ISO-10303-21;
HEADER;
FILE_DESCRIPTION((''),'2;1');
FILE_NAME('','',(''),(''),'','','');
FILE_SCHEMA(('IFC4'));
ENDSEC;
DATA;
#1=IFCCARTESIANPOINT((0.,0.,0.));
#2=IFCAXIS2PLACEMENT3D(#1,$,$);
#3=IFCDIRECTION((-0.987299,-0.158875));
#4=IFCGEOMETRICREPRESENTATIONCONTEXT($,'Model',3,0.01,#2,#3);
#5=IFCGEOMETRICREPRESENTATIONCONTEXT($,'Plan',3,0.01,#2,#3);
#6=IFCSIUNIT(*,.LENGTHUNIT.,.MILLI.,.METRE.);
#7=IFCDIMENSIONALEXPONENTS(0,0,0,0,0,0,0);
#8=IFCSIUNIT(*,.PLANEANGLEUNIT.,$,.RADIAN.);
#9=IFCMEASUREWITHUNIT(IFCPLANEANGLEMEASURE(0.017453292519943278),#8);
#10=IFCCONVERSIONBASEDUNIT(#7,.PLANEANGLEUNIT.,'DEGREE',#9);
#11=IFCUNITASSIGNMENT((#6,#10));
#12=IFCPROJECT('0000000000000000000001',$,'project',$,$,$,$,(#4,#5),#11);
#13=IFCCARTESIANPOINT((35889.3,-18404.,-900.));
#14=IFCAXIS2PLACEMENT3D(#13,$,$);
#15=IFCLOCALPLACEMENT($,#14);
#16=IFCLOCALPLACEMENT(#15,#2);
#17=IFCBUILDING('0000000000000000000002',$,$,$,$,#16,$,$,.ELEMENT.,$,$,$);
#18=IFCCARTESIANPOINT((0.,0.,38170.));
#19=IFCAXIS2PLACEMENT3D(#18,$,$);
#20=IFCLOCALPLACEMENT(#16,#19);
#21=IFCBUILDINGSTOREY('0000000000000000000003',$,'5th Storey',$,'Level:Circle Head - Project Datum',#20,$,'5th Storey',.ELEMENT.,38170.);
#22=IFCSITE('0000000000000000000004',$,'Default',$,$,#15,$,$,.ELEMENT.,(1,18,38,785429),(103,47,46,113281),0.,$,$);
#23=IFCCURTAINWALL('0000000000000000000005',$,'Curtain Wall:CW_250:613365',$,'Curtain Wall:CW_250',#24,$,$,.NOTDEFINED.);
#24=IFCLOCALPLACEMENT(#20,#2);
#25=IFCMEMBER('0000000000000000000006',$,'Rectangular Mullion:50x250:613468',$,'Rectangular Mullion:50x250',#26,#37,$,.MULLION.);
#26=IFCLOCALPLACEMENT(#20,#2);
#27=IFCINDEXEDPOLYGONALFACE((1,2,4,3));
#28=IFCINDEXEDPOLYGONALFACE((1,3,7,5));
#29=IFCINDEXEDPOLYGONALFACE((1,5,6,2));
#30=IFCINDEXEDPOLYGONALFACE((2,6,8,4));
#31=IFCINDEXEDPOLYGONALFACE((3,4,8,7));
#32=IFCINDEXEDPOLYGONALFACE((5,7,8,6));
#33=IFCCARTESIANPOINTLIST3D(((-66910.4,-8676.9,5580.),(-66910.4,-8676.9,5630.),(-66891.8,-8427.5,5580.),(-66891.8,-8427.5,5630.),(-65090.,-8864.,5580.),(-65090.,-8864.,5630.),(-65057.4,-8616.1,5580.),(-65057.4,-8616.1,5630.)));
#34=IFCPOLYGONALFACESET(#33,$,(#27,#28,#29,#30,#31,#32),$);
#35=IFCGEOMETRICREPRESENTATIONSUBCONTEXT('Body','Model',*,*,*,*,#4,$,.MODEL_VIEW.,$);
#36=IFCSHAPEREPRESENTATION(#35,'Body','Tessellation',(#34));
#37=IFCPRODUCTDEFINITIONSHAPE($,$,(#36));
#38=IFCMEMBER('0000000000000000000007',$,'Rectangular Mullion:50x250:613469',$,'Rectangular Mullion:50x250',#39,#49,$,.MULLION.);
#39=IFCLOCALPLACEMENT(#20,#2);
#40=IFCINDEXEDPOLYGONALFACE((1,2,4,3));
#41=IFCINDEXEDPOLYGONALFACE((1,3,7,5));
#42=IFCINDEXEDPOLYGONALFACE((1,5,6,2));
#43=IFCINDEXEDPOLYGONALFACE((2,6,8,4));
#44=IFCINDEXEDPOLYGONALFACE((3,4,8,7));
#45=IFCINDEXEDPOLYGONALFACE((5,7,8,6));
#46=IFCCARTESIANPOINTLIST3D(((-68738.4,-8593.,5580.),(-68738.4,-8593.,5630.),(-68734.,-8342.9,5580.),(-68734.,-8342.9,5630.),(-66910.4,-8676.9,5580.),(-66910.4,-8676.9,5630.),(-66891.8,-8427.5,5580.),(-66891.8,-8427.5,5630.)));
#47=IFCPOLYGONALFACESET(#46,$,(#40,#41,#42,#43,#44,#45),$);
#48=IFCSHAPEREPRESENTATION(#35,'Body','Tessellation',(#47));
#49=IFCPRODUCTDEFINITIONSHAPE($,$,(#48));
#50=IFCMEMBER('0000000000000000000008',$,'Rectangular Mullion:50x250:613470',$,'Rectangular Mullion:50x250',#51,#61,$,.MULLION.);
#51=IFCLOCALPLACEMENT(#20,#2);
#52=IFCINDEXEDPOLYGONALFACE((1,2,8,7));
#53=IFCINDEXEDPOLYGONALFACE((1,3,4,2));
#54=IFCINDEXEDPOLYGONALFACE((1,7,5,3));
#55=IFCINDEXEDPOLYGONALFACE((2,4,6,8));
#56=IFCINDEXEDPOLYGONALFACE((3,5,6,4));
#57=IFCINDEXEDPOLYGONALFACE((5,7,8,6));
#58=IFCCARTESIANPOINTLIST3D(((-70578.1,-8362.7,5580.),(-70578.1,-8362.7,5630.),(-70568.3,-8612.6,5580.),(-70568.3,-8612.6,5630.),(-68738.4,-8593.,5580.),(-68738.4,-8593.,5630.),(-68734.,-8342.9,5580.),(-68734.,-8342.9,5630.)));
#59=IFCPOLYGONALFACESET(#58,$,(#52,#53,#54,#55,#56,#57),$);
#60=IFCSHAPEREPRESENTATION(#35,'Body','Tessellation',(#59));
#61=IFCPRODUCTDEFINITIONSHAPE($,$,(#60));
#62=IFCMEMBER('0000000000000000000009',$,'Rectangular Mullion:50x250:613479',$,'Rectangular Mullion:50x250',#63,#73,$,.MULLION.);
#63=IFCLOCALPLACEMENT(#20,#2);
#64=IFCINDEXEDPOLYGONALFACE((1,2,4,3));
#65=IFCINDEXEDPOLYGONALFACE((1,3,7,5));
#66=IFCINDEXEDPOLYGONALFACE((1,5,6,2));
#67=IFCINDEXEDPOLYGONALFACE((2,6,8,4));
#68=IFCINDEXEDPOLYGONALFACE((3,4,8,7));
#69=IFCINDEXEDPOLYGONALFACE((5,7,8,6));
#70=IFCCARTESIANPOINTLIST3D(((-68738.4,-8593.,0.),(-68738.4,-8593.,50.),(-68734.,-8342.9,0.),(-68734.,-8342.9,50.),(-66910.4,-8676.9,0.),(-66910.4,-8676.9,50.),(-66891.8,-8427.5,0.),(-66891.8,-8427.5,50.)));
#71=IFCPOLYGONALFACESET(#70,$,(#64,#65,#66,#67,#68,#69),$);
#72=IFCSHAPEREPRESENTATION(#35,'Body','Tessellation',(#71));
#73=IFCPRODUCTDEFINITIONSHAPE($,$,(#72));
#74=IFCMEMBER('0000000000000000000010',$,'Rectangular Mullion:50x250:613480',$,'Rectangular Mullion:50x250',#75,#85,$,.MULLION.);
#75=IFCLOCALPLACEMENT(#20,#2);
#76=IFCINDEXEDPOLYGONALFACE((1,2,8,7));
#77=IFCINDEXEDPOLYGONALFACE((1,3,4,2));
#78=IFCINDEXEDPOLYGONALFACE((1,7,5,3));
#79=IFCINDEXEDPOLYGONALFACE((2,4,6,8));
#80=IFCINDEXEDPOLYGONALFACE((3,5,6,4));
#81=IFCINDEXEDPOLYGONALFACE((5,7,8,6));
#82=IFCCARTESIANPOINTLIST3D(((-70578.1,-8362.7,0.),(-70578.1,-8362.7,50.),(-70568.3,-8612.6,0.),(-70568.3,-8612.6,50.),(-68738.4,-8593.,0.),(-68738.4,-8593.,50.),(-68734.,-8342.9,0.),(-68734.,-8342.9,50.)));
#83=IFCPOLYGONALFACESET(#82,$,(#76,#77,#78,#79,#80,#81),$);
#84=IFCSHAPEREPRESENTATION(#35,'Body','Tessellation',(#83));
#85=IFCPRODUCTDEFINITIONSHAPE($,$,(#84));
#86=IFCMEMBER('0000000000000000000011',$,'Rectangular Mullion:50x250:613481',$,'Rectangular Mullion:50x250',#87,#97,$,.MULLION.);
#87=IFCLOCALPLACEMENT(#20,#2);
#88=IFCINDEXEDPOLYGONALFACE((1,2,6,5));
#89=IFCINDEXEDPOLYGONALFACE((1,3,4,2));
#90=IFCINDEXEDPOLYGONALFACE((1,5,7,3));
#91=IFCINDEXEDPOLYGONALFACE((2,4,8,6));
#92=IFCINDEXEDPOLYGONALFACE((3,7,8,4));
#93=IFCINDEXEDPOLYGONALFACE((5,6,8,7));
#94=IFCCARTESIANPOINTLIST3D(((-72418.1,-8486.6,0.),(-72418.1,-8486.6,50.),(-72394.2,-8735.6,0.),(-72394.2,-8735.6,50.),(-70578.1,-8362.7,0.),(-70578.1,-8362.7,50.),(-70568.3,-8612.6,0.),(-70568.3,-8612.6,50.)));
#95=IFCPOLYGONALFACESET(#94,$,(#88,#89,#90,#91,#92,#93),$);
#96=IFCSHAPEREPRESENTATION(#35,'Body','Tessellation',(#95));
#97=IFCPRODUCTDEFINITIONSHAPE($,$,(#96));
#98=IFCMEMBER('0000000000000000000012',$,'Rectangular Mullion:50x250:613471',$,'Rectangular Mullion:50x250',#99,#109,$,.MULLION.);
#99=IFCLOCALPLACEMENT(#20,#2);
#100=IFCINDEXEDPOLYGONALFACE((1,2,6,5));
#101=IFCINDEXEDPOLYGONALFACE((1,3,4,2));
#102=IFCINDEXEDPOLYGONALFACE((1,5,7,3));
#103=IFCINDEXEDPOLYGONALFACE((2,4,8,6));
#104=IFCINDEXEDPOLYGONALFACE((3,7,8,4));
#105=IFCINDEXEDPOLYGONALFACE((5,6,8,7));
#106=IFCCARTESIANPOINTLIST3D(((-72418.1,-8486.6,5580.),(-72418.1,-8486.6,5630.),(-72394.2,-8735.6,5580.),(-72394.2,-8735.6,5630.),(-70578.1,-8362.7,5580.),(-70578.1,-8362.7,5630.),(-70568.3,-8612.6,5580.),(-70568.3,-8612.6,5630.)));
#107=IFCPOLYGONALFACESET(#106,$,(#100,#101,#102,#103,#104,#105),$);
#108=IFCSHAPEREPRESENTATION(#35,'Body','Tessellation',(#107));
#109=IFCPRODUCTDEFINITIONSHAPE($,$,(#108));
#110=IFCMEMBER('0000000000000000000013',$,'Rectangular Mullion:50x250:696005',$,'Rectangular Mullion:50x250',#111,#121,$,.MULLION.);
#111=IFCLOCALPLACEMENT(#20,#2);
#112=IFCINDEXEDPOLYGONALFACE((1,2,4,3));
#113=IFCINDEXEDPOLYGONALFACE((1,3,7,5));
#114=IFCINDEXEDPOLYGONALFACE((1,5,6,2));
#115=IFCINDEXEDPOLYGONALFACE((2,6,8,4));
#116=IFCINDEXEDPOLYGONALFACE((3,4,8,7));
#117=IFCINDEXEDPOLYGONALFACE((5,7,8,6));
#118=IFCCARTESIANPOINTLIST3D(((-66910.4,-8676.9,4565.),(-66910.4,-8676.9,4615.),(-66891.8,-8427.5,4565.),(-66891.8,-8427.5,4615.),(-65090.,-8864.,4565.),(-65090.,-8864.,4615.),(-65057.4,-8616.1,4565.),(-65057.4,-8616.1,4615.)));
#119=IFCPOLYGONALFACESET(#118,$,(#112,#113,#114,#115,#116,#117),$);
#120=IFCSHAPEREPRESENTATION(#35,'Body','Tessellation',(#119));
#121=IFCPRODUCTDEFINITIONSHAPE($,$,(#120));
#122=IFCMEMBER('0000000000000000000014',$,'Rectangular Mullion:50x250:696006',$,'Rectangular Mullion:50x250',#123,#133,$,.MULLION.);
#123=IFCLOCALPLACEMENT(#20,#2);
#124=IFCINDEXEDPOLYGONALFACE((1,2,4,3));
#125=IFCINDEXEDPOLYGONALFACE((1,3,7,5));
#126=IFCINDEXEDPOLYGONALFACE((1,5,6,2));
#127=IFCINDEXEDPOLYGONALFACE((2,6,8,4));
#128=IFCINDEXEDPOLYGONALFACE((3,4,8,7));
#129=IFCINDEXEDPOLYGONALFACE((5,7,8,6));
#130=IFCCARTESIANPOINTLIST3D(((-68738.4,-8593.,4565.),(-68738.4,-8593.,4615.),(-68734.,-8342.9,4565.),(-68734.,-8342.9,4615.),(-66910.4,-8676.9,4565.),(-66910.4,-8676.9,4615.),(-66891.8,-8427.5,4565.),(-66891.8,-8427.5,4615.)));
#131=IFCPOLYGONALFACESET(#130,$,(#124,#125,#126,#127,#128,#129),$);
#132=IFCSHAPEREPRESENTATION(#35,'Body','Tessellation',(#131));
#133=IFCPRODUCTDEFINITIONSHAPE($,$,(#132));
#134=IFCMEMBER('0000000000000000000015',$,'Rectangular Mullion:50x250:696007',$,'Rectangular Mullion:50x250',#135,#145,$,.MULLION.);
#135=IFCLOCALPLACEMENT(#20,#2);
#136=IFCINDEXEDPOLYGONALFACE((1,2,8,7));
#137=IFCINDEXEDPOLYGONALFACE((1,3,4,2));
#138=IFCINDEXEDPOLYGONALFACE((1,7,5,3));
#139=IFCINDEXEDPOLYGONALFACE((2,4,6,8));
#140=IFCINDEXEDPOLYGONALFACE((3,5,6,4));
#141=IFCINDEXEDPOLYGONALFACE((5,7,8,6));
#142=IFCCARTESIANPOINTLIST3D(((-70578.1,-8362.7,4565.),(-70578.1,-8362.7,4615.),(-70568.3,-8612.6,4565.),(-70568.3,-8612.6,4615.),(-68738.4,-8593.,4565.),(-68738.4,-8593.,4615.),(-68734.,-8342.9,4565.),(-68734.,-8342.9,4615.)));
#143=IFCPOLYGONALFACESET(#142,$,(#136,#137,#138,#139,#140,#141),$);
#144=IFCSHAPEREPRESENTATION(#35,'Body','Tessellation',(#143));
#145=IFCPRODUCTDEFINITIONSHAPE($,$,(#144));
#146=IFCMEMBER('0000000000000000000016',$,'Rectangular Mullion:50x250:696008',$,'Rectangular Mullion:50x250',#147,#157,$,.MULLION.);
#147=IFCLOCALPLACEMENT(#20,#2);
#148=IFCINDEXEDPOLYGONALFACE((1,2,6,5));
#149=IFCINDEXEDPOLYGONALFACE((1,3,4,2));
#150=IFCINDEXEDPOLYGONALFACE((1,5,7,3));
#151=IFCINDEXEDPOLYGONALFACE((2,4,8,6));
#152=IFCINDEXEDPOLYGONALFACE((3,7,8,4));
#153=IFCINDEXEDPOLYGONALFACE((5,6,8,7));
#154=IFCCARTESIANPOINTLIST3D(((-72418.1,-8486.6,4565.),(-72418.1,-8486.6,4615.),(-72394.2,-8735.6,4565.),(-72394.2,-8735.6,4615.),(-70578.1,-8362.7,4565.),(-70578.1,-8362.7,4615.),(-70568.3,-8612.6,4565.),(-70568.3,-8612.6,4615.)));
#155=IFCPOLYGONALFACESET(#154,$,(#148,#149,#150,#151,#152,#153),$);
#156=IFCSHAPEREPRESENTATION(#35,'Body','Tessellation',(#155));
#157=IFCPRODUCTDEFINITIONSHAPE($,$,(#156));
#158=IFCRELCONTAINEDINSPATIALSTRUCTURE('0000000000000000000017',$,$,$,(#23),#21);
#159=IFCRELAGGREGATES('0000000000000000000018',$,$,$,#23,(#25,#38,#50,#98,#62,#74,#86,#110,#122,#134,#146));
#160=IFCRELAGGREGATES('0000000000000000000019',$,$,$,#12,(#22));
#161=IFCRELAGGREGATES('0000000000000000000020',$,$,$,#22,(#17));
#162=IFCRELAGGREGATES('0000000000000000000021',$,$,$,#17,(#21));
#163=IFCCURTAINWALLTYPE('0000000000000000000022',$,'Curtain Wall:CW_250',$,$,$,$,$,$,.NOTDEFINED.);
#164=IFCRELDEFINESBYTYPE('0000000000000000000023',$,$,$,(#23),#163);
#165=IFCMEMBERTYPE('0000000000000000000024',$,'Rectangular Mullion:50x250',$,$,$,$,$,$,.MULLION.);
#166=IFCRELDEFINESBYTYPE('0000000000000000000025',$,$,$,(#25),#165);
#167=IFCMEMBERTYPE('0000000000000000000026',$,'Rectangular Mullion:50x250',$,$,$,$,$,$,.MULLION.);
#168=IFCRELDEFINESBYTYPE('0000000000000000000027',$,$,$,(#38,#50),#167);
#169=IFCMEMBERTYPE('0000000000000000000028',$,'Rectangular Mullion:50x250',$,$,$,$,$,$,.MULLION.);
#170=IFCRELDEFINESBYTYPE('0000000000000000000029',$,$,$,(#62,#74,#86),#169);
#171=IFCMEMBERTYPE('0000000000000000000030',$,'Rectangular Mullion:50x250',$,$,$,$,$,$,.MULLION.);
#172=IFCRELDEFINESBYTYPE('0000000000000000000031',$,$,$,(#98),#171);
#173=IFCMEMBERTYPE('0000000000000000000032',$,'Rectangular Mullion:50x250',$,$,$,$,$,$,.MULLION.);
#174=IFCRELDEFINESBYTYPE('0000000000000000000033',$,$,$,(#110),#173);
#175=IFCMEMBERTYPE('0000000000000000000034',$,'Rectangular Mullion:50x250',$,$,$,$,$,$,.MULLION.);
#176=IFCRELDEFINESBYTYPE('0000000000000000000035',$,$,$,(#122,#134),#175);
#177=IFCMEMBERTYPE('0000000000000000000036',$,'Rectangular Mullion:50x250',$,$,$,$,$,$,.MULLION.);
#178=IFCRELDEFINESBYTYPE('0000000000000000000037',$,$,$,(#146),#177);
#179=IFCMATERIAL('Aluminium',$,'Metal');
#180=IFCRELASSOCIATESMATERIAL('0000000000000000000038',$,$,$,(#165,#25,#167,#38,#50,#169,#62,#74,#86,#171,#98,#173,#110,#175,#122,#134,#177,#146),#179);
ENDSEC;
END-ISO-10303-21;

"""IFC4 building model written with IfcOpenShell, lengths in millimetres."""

from ifc_helpers import new_model, entity, si_unit, converted_unit, direction, frame, origin, place, context, subcontext, project, spatial, indexed_curve, outline, extrude, source, transform, mapped, material, type_object, type_shapes, element, aggregate, save


model = new_model("IFC4")

# Units and contexts
model_context = context("Model", 3, precision=0.01, world=origin(), true_north=direction((-0.987299, -0.158875)))
plan_context = context("Plan", 3, precision=0.01, world=origin(), true_north=direction((-0.987299, -0.158875)))
body_context = subcontext(model_context, "Body", "Model", "MODEL_VIEW")
ifc_project = project(units=[si_unit("LENGTHUNIT", "METRE", prefix="MILLI"), converted_unit("PLANEANGLEUNIT", "DEGREE", entity("IfcPlaneAngleMeasure", 0.017453292519943278), si_unit("PLANEANGLEUNIT", "RADIAN"), dimensions=[0, 0, 0, 0, 0, 0, 0])], contexts=[model_context, plan_context])

# Site, building, storey
site_placement = place(None, frame((35889.3, -18404.0, -900.0)))
site = spatial("IfcSite", under=ifc_project, at=site_placement, Name="Default", CompositionType="ELEMENT", RefLatitude=(1, 18, 38, 785429), RefLongitude=(103, 47, 46, 113281), RefElevation=0.0)
building_placement = place(site_placement, origin())
building = spatial("IfcBuilding", under=site, at=building_placement, CompositionType="ELEMENT")
storey_placement = place(building_placement, frame((0.0, 0.0, 38170.0)))
storey = spatial("IfcBuildingStorey", under=building, at=storey_placement, Name="5th Storey", ObjectType="Level:Circle Head - Project Datum", LongName="5th Storey", CompositionType="ELEMENT", Elevation=38170.0)

# Curtain wall, members
curtain_wall_type = type_object("IfcCurtainWallType", Name="Curtain Wall:CW_250", PredefinedType="NOTDEFINED")
curtain_wall_placement = place(storey_placement, frame((0.0, 0.0, -38170.0)))
curtain_wall = element("IfcCurtainWall", 1, at=curtain_wall_placement, inside=storey, type_object=curtain_wall_type, Name="Curtain Wall:CW_250:613365", ObjectType="Curtain Wall:CW_250", PredefinedType="NOTDEFINED")
ifc_material_1 = material(Name="Aluminium", Category="Metal")
member_type_1 = type_object("IfcMemberType", Name="Rectangular Mullion:50x250", PredefinedType="MULLION", material=ifc_material_1)
shared_shape_1 = source(origin(), body_context, "Body", "SweptSolid", [
    extrude(outline(indexed_curve([(-915.0, -125.0), (915.0, -125.0), (922.1, 125.0), (-922.1, 125.0), (-915.0, -125.0)], self_intersect=False)), frame((-50.0, 125.0, -915.0), z_axis=(1.0, 0.0, 0.0), x_axis=(0.0, 0.0, -1.0)), (0.0, 0.0, 1.0), 50.0),
])
type_shapes(member_type_1, [shared_shape_1])
member_1_placement = place(curtain_wall_placement, frame((-66910.4, -8676.9, 43800.0), z_axis=(-0.994757, 0.102268, 0.0), x_axis=(0.0, 0.0, 1.0)))
member_1 = element("IfcMember", 2, at=member_1_placement, type_object=member_type_1, material=ifc_material_1, Name="Rectangular Mullion:50x250:613468", ObjectType="Rectangular Mullion:50x250", PredefinedType="MULLION", context=body_context, shape_type="MappedRepresentation", body=[
    mapped(shared_shape_1, transform((0.0, 0.0, 0.0), scale=1.0)),
])
member_type_2 = type_object("IfcMemberType", Name="Rectangular Mullion:50x250", PredefinedType="MULLION", material=ifc_material_1)
shared_shape_2 = source(origin(), body_context, "Body", "SweptSolid", [
    extrude(outline(indexed_curve([(-915.0, -125.0), (915.0, -125.0), (922.1, 125.0), (-922.1, 125.0), (-915.0, -125.0)], self_intersect=False)), frame((-50.0, 125.0, -915.0), z_axis=(1.0, 0.0, 0.0), x_axis=(0.0, 0.0, -1.0)), (0.0, 0.0, 1.0), 50.0),
])
type_shapes(member_type_2, [shared_shape_2])
member_2_placement = place(curtain_wall_placement, frame((-68738.4, -8593.0, 43800.0), z_axis=(-0.998948, 0.045855, 0.0), x_axis=(0.0, 0.0, 1.0)))
member_2 = element("IfcMember", 3, at=member_2_placement, type_object=member_type_2, material=ifc_material_1, Name="Rectangular Mullion:50x250:613469", ObjectType="Rectangular Mullion:50x250", PredefinedType="MULLION", context=body_context, shape_type="MappedRepresentation", body=[
    mapped(shared_shape_2, transform((0.0, 0.0, 0.0), scale=1.0)),
])
member_3_placement = place(curtain_wall_placement, frame((-70568.3, -8612.6, 43800.0), z_axis=(-0.999943, -0.010705, 0.0), x_axis=(0.0, 0.0, 1.0)))
member_3 = element("IfcMember", 4, at=member_3_placement, type_object=member_type_2, material=ifc_material_1, Name="Rectangular Mullion:50x250:613470", ObjectType="Rectangular Mullion:50x250", PredefinedType="MULLION", context=body_context, shape_type="MappedRepresentation", body=[
    mapped(shared_shape_2, transform((0.0, 0.0, 0.0), scale=1.0)),
])
member_type_3 = type_object("IfcMemberType", Name="Rectangular Mullion:50x250", PredefinedType="MULLION", material=ifc_material_1)
shared_shape_3 = source(origin(), body_context, "Body", "SweptSolid", [
    extrude(outline(indexed_curve([(-915.0, -125.0), (915.0, -125.0), (922.1, 125.0), (-922.1, 125.0), (-915.0, -125.0)], self_intersect=False)), frame((-50.0, 125.0, -915.0), z_axis=(1.0, 0.0, 0.0), x_axis=(0.0, 0.0, -1.0)), (0.0, 0.0, 1.0), 50.0),
])
type_shapes(member_type_3, [shared_shape_3])
member_4_placement = place(curtain_wall_placement, frame((-66910.4, -8676.9, 38170.0), z_axis=(0.998948, -0.045855, 0.0), x_axis=(0.0, 0.0, -1.0)))
member_4 = element("IfcMember", 5, at=member_4_placement, type_object=member_type_3, material=ifc_material_1, Name="Rectangular Mullion:50x250:613479", ObjectType="Rectangular Mullion:50x250", PredefinedType="MULLION", context=body_context, shape_type="MappedRepresentation", body=[
    mapped(shared_shape_3, transform((0.0, 0.0, 0.0), scale=1.0)),
])
member_5_placement = place(curtain_wall_placement, frame((-68738.4, -8593.0, 38170.0), z_axis=(0.999943, 0.010705, 0.0), x_axis=(0.0, 0.0, -1.0)))
member_5 = element("IfcMember", 6, at=member_5_placement, type_object=member_type_3, material=ifc_material_1, Name="Rectangular Mullion:50x250:613480", ObjectType="Rectangular Mullion:50x250", PredefinedType="MULLION", context=body_context, shape_type="MappedRepresentation", body=[
    mapped(shared_shape_3, transform((0.0, 0.0, 0.0), scale=1.0)),
])
member_6_placement = place(curtain_wall_placement, frame((-70568.3, -8612.6, 38170.0), z_axis=(0.997737, 0.067231, 0.0), x_axis=(0.0, 0.0, -1.0)))
member_6 = element("IfcMember", 7, at=member_6_placement, type_object=member_type_3, material=ifc_material_1, Name="Rectangular Mullion:50x250:613481", ObjectType="Rectangular Mullion:50x250", PredefinedType="MULLION", context=body_context, shape_type="MappedRepresentation", body=[
    mapped(shared_shape_3, transform((0.0, 0.0, 0.0), scale=1.0)),
])
member_type_4 = type_object("IfcMemberType", Name="Rectangular Mullion:50x250", PredefinedType="MULLION", material=ifc_material_1)
shared_shape_4 = source(origin(), body_context, "Body", "SweptSolid", [
    extrude(outline(indexed_curve([(-915.0, -125.0), (915.0, -125.0), (922.1, 125.0), (-922.1, 125.0), (-915.0, -125.0)], self_intersect=False)), frame((-50.0, 125.0, -915.0), z_axis=(1.0, 0.0, 0.0), x_axis=(0.0, 0.0, -1.0)), (0.0, 0.0, 1.0), 50.0),
])
type_shapes(member_type_4, [shared_shape_4])
member_7_placement = place(curtain_wall_placement, frame((-72394.2, -8735.6, 43800.0), z_axis=(-0.997737, -0.067231, 0.0), x_axis=(0.0, 0.0, 1.0)))
member_7 = element("IfcMember", 8, at=member_7_placement, type_object=member_type_4, material=ifc_material_1, Name="Rectangular Mullion:50x250:613471", ObjectType="Rectangular Mullion:50x250", PredefinedType="MULLION", context=body_context, shape_type="MappedRepresentation", body=[
    mapped(shared_shape_4, transform((0.0, 0.0, 0.0), scale=1.0)),
])
member_type_5 = type_object("IfcMemberType", Name="Rectangular Mullion:50x250", PredefinedType="MULLION", material=ifc_material_1)
shared_shape_5 = source(origin(), body_context, "Body", "SweptSolid", [
    extrude(outline(indexed_curve([(-915.0, -125.0), (915.0, -125.0), (922.1, 125.0), (-922.1, 125.0), (-915.0, -125.0)], self_intersect=False)), frame((-25.0, 125.0, -915.0), z_axis=(1.0, 0.0, 0.0), x_axis=(0.0, 0.0, -1.0)), (0.0, 0.0, 1.0), 50.0),
])
type_shapes(member_type_5, [shared_shape_5])
member_8_placement = place(curtain_wall_placement, frame((-66910.4, -8676.9, 42760.0), z_axis=(-0.994757, 0.102268, 0.0), x_axis=(0.0, 0.0, 1.0)))
member_8 = element("IfcMember", 9, at=member_8_placement, type_object=member_type_5, material=ifc_material_1, Name="Rectangular Mullion:50x250:696005", ObjectType="Rectangular Mullion:50x250", PredefinedType="MULLION", context=body_context, shape_type="MappedRepresentation", body=[
    mapped(shared_shape_5, transform((0.0, 0.0, 0.0), scale=1.0)),
])
member_type_6 = type_object("IfcMemberType", Name="Rectangular Mullion:50x250", PredefinedType="MULLION", material=ifc_material_1)
shared_shape_6 = source(origin(), body_context, "Body", "SweptSolid", [
    extrude(outline(indexed_curve([(-915.0, -125.0), (915.0, -125.0), (922.1, 125.0), (-922.1, 125.0), (-915.0, -125.0)], self_intersect=False)), frame((-25.0, 125.0, -915.0), z_axis=(1.0, 0.0, 0.0), x_axis=(0.0, 0.0, -1.0)), (0.0, 0.0, 1.0), 50.0),
])
type_shapes(member_type_6, [shared_shape_6])
member_9_placement = place(curtain_wall_placement, frame((-68738.4, -8593.0, 42760.0), z_axis=(-0.998948, 0.045855, 0.0), x_axis=(0.0, 0.0, 1.0)))
member_9 = element("IfcMember", 10, at=member_9_placement, type_object=member_type_6, material=ifc_material_1, Name="Rectangular Mullion:50x250:696006", ObjectType="Rectangular Mullion:50x250", PredefinedType="MULLION", context=body_context, shape_type="MappedRepresentation", body=[
    mapped(shared_shape_6, transform((0.0, 0.0, 0.0), scale=1.0)),
])
member_10_placement = place(curtain_wall_placement, frame((-70568.3, -8612.6, 42760.0), z_axis=(-0.999943, -0.010705, 0.0), x_axis=(0.0, 0.0, 1.0)))
member_10 = element("IfcMember", 11, at=member_10_placement, type_object=member_type_6, material=ifc_material_1, Name="Rectangular Mullion:50x250:696007", ObjectType="Rectangular Mullion:50x250", PredefinedType="MULLION", context=body_context, shape_type="MappedRepresentation", body=[
    mapped(shared_shape_6, transform((0.0, 0.0, 0.0), scale=1.0)),
])
member_type_7 = type_object("IfcMemberType", Name="Rectangular Mullion:50x250", PredefinedType="MULLION", material=ifc_material_1)
shared_shape_7 = source(origin(), body_context, "Body", "SweptSolid", [
    extrude(outline(indexed_curve([(-915.0, -125.0), (915.0, -125.0), (922.1, 125.0), (-922.1, 125.0), (-915.0, -125.0)], self_intersect=False)), frame((-25.0, 125.0, -915.0), z_axis=(1.0, 0.0, 0.0), x_axis=(0.0, 0.0, -1.0)), (0.0, 0.0, 1.0), 50.0),
])
type_shapes(member_type_7, [shared_shape_7])
member_11_placement = place(curtain_wall_placement, frame((-72394.2, -8735.6, 42760.0), z_axis=(-0.997737, -0.067231, 0.0), x_axis=(0.0, 0.0, 1.0)))
member_11 = element("IfcMember", 12, at=member_11_placement, type_object=member_type_7, material=ifc_material_1, Name="Rectangular Mullion:50x250:696008", ObjectType="Rectangular Mullion:50x250", PredefinedType="MULLION", context=body_context, shape_type="MappedRepresentation", body=[
    mapped(shared_shape_7, transform((0.0, 0.0, 0.0), scale=1.0)),
])
aggregate(curtain_wall, [member_1, member_2, member_3, member_7, member_4, member_5, member_6, member_8, member_9, member_10, member_11])

save(model, "model.ifc")
